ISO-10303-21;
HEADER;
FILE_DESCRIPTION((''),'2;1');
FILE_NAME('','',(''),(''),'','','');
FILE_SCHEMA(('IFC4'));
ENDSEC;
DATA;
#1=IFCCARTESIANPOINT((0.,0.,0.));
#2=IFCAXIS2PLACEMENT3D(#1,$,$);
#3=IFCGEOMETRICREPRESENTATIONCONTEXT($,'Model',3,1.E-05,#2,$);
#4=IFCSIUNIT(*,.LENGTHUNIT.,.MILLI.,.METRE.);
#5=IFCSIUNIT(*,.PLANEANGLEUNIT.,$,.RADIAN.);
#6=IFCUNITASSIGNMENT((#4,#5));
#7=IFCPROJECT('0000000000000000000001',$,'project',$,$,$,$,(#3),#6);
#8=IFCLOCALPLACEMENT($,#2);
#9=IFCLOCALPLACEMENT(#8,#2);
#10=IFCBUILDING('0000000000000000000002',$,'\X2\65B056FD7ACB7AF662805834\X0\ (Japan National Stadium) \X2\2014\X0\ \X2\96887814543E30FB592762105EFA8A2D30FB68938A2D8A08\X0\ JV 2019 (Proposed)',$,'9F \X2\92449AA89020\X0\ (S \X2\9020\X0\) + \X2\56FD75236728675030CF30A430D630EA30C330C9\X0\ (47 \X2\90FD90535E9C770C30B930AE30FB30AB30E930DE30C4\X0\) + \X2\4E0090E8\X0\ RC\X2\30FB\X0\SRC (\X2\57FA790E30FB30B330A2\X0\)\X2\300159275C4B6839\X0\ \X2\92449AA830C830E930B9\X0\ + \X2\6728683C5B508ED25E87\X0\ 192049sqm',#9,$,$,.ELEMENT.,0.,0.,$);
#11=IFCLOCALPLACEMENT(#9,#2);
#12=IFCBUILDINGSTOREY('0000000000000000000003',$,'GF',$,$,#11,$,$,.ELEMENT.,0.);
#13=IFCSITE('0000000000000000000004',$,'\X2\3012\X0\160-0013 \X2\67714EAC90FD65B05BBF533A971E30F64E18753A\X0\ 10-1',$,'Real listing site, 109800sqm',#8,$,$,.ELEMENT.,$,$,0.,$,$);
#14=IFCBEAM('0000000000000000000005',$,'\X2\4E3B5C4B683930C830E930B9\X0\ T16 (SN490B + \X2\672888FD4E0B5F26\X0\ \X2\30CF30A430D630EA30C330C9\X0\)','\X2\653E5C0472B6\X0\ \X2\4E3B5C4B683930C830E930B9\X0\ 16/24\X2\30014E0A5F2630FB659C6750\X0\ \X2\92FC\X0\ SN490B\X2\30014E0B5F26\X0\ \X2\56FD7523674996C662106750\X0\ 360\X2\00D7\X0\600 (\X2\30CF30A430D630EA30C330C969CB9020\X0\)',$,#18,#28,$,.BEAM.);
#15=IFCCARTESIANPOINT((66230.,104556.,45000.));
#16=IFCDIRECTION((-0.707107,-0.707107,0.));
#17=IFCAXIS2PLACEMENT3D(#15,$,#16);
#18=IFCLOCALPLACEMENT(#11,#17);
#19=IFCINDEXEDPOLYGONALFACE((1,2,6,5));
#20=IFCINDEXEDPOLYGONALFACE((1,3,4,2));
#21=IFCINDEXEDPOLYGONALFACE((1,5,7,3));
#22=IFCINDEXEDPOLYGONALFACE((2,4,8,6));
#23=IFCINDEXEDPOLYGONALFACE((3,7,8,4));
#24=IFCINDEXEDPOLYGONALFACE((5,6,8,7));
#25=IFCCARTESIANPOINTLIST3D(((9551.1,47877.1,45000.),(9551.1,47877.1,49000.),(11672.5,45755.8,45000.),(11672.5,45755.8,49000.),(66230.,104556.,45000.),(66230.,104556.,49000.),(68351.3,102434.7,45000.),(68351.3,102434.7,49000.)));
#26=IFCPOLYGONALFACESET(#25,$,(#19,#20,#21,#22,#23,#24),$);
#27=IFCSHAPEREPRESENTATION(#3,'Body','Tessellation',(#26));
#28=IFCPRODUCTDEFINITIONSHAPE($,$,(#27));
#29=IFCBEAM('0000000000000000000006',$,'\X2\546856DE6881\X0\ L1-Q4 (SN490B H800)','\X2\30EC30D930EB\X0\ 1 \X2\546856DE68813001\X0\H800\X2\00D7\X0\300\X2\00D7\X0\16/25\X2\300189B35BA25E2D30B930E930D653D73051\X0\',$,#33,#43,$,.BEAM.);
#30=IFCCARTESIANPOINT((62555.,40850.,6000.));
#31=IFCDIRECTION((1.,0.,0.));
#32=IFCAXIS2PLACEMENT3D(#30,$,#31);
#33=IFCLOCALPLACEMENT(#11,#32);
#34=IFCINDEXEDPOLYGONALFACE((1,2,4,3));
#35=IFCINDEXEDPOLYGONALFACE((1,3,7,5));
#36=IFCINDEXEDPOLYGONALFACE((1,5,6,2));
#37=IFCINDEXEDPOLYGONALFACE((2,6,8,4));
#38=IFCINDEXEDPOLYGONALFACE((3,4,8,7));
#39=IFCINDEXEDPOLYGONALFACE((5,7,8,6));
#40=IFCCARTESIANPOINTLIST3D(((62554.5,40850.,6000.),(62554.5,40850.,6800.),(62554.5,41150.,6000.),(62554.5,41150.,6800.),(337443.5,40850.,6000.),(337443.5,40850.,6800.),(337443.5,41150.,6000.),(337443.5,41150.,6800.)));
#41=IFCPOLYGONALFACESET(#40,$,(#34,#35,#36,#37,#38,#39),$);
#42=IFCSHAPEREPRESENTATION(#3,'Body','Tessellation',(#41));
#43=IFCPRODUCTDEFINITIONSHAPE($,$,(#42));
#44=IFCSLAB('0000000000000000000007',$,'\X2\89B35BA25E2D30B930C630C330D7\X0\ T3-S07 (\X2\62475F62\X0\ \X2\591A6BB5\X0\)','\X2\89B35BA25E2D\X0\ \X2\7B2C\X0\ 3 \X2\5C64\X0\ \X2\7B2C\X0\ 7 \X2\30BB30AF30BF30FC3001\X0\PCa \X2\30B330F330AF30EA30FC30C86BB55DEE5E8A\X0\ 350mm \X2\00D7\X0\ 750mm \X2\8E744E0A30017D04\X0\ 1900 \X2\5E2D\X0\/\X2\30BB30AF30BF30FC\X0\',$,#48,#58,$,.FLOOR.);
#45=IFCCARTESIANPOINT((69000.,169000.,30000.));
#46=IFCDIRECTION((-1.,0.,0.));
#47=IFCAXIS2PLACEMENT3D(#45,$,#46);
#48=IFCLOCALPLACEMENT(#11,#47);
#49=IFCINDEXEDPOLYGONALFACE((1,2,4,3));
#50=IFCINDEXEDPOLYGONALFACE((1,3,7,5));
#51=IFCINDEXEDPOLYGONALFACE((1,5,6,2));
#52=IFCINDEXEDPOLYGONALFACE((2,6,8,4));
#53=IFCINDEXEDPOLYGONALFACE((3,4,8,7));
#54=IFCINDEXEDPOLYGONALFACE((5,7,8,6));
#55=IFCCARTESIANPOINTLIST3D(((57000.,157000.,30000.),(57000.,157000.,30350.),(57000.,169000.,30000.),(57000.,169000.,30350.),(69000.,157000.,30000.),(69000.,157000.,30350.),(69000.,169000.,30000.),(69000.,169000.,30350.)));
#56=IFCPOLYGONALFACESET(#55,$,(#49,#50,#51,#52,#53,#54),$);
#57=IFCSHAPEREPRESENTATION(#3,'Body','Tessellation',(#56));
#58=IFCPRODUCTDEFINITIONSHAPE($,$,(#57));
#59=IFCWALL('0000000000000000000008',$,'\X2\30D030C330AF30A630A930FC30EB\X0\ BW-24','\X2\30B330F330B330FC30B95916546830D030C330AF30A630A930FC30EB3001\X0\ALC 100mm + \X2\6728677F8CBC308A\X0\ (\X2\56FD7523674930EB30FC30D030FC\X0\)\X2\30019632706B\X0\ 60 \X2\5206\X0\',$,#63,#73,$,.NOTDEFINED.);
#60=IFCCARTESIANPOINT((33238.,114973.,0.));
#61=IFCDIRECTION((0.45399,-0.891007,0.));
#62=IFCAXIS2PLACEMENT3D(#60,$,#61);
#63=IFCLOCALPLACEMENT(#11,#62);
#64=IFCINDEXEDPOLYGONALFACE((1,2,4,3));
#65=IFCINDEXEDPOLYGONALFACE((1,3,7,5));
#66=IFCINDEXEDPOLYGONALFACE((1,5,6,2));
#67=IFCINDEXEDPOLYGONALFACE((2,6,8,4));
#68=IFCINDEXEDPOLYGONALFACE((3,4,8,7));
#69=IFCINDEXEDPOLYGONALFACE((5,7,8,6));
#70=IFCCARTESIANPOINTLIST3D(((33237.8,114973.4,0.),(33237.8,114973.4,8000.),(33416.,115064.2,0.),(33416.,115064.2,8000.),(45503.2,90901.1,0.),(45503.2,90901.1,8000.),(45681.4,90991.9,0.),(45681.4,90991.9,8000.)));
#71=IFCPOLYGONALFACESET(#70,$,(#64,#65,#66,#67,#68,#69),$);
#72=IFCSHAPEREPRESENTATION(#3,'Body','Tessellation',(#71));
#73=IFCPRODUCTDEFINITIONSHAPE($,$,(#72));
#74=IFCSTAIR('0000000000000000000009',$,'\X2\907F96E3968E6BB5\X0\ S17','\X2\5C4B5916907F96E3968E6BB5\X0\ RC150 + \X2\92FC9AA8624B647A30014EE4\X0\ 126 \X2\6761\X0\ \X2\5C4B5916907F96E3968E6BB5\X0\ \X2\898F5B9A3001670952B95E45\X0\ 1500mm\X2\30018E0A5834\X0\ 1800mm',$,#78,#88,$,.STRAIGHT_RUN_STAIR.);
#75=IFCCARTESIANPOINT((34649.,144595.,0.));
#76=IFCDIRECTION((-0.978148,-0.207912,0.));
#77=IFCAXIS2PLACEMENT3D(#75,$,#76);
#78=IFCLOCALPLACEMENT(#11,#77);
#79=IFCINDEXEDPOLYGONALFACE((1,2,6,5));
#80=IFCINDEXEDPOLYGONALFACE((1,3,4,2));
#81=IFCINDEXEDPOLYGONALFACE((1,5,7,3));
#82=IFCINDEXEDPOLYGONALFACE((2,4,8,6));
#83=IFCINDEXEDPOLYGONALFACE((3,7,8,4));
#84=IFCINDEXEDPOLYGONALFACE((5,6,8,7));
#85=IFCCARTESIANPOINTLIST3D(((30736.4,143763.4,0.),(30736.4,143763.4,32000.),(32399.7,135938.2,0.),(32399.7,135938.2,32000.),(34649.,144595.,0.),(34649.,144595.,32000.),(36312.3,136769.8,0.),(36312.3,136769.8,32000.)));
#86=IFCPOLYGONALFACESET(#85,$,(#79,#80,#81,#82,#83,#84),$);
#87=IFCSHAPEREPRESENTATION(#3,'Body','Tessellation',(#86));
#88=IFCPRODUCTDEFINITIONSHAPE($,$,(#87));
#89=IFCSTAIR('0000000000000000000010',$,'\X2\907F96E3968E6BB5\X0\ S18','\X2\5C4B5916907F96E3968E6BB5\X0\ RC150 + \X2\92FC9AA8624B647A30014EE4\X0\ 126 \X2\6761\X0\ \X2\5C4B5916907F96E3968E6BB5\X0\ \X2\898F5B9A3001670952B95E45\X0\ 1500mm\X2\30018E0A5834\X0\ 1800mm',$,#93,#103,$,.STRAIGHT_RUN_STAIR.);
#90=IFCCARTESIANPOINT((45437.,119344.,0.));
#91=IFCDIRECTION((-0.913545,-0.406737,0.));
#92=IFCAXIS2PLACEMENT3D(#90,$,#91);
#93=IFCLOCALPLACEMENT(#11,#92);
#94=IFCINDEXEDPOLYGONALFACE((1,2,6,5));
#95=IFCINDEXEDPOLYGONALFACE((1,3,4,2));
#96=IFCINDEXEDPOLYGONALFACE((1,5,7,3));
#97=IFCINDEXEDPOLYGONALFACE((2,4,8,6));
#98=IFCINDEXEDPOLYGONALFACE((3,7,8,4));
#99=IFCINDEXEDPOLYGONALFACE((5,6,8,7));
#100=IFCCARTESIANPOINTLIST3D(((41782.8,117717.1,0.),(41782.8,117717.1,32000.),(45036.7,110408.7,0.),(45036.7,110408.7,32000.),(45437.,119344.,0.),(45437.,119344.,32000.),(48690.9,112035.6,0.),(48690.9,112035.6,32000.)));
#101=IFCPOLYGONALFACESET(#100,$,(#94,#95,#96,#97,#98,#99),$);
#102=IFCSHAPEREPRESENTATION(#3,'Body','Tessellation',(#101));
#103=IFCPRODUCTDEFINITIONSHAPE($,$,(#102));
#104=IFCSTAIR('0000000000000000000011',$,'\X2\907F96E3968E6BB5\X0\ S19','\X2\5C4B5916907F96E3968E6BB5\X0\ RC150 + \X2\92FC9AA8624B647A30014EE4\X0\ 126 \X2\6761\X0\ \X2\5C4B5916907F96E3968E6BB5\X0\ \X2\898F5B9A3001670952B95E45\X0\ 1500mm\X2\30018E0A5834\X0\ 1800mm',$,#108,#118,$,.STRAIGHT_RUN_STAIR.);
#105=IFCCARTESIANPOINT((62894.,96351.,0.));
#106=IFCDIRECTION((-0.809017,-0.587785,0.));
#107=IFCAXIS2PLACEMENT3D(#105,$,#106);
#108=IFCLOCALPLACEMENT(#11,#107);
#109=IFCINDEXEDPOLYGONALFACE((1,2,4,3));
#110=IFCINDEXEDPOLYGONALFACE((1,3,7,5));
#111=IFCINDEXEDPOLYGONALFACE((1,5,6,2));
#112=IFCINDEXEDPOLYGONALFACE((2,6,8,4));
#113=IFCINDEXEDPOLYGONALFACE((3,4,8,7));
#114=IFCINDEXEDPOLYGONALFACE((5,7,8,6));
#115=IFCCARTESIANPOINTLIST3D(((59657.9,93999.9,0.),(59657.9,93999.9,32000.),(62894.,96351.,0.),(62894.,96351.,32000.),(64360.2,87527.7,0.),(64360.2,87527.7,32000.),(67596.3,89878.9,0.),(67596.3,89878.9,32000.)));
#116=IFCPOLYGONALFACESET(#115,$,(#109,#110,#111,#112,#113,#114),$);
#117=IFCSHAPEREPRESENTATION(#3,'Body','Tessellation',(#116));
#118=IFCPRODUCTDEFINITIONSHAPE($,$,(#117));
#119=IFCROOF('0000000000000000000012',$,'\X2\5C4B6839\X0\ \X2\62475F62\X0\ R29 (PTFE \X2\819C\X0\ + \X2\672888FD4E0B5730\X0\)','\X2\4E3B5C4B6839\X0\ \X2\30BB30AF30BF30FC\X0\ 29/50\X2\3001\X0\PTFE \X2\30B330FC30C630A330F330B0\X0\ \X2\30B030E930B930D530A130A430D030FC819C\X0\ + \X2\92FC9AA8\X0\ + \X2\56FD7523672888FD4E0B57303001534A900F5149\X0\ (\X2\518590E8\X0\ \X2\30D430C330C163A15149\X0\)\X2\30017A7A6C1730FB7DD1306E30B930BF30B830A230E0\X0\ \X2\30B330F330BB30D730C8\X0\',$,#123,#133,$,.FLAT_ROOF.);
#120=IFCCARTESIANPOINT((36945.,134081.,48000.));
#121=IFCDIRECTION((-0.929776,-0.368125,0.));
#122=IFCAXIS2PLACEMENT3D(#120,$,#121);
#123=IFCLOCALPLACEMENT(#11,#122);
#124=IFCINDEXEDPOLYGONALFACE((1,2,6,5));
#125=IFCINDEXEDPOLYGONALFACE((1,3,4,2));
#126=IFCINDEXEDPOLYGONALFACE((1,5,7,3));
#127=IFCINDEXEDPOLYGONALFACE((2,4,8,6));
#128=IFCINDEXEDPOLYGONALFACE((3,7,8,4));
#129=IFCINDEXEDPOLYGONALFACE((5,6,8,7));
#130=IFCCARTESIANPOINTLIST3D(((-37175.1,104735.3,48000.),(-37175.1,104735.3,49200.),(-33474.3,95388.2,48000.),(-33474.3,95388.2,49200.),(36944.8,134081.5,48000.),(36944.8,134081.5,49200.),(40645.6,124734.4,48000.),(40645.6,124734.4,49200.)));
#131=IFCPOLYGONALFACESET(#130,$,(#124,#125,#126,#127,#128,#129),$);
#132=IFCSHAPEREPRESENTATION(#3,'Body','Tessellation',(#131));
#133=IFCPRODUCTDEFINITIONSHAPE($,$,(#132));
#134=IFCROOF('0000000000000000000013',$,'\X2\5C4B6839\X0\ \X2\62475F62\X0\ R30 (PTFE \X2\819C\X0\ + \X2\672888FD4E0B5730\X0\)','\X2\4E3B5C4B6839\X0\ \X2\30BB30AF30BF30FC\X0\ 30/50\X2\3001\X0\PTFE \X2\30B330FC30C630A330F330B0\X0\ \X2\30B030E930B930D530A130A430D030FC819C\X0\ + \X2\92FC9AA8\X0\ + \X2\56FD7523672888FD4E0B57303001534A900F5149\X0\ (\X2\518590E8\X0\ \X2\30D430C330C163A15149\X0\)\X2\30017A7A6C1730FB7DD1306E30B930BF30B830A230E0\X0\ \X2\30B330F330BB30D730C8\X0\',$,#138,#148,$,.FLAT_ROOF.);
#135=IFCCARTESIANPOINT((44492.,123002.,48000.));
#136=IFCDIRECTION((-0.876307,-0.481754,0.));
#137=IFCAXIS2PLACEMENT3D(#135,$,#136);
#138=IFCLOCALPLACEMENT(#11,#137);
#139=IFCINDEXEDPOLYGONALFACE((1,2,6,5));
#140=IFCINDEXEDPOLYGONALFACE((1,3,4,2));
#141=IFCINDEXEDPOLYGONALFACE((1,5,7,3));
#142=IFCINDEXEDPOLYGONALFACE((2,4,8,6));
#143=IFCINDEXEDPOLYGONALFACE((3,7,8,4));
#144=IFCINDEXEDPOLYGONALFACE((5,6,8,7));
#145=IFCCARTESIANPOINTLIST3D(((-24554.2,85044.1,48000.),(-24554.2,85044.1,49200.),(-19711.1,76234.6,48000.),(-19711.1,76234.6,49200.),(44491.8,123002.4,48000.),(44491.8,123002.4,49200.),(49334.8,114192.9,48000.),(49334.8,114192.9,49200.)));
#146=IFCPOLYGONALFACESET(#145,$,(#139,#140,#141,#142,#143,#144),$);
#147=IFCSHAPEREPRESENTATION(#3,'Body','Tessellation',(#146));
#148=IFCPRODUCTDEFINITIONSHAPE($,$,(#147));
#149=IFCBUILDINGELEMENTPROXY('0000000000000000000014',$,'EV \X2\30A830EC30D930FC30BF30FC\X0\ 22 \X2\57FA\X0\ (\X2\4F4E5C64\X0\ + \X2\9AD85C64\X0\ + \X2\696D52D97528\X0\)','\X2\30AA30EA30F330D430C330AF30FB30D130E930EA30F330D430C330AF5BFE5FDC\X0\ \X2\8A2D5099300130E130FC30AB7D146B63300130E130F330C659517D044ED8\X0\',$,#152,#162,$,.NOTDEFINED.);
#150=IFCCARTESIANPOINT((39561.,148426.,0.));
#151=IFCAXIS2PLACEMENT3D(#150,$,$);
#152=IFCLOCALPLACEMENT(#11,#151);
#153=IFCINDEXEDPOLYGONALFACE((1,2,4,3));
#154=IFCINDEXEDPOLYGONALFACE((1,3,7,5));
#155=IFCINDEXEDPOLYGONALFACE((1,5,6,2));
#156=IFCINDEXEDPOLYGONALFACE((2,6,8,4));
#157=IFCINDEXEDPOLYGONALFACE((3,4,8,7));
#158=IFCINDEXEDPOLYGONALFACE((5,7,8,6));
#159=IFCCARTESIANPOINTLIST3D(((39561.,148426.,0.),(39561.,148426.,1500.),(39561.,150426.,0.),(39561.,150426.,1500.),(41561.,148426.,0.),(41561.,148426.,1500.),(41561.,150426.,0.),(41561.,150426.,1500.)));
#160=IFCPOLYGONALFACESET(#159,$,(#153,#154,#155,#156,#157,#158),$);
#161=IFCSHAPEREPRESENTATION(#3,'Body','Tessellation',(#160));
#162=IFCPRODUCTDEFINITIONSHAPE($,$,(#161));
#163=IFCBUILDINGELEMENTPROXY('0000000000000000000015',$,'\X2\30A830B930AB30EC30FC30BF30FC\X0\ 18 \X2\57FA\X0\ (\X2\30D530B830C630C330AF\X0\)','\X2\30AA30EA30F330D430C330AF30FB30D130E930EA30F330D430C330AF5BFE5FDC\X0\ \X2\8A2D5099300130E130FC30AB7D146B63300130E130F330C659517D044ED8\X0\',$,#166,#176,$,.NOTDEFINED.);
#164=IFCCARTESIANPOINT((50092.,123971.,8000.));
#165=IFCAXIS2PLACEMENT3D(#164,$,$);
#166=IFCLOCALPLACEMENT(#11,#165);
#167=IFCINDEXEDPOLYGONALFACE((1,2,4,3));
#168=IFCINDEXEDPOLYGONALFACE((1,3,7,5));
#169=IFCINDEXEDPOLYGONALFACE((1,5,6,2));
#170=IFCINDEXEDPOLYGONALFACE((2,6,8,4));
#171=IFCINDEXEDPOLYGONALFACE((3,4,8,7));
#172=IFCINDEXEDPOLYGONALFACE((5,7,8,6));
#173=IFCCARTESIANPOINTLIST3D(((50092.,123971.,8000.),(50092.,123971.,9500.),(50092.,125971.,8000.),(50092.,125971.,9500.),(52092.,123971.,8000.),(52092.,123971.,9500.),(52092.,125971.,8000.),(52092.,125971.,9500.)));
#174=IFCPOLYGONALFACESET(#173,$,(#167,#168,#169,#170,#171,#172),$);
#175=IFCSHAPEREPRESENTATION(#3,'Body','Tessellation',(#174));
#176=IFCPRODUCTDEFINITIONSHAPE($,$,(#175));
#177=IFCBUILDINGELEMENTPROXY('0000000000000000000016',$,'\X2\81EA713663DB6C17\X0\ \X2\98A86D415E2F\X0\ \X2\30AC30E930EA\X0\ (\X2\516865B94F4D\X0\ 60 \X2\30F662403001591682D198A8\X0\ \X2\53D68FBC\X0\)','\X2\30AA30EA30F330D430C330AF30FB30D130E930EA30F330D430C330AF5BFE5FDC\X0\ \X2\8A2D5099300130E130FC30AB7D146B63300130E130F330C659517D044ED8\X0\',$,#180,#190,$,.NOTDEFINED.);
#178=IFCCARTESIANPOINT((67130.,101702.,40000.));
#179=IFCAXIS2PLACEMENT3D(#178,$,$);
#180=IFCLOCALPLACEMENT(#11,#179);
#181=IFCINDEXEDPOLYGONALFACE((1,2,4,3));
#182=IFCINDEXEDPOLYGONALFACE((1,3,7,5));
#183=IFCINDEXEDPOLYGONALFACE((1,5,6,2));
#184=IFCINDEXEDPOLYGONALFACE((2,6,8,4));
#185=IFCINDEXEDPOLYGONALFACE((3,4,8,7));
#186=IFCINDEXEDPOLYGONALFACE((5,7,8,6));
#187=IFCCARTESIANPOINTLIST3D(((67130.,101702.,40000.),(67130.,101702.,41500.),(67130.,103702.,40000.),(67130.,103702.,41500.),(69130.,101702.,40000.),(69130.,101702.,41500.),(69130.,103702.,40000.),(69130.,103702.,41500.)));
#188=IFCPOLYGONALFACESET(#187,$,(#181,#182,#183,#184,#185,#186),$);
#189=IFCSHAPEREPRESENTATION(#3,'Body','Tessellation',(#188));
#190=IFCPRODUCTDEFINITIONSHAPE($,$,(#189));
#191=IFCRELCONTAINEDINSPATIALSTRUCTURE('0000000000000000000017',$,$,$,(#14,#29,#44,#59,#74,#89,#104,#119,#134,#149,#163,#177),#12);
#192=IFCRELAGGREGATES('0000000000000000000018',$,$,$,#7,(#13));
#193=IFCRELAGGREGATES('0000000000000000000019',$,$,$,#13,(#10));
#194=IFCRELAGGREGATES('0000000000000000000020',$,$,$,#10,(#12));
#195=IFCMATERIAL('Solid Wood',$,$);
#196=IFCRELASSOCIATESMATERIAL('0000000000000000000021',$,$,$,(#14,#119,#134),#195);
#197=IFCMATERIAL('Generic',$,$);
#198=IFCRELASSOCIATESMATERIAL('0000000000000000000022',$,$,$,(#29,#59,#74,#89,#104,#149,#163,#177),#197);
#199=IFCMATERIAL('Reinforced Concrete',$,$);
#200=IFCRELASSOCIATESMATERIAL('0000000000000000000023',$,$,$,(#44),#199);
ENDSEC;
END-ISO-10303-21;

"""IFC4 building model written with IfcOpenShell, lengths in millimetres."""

from ifc_helpers import new_model, si_unit, frame, frame_2d, origin, place, context, project, spatial, rectangle, extrude, material, element, save


model = new_model("IFC4")

# Units and contexts
model_context = context("Model", 3, precision=1e-05, world=origin())
ifc_project = project(units=[si_unit("LENGTHUNIT", "METRE", prefix="MILLI"), si_unit("PLANEANGLEUNIT", "RADIAN")], contexts=[model_context])

# Site, building, storey
site_placement = place(None, origin())
site = spatial("IfcSite", under=ifc_project, at=site_placement, Name="〒160-0013 東京都新宿区霞ヶ丘町 10-1", ObjectType="Real listing site, 109800sqm", CompositionType="ELEMENT", RefElevation=0.0)
building_placement = place(site_placement, origin())
building = spatial("IfcBuilding", under=site, at=building_placement, Name="新国立競技場 (Japan National Stadium) — 隈研吾・大成建設・梓設計 JV 2019 (Proposed)", ObjectType="9F 鉄骨造 (S 造) + 国産木材ハイブリッド (47 都道府県スギ・カラマツ) + 一部 RC・SRC (基礎・コア)、大屋根 鉄骨トラス + 木格子軒庇 192049sqm", CompositionType="ELEMENT", ElevationOfRefHeight=0.0, ElevationOfTerrain=0.0)
storey_placement = place(building_placement, origin())
storey = spatial("IfcBuildingStorey", under=building, at=storey_placement, Name="GF", CompositionType="ELEMENT", Elevation=0.0)

# Shared definitions
ifc_material_1 = material(Name="Reinforced Concrete")

# Shared definitions
ifc_material_2 = material(Name="Generic")

# Beams
ifc_material_3 = material(Name="Solid Wood")
beam_1_placement = place(storey_placement, frame((66230.0, 104556.0, 45000.0), x_axis=(-0.707107, -0.707107, 0.0)))
element("IfcBeam", 1, at=beam_1_placement, inside=storey, material=ifc_material_3, Name="主屋根トラス T16 (SN490B + 木製下弦 ハイブリッド)", Description="放射状 主屋根トラス 16/24、上弦・斜材 鋼 SN490B、下弦 国産杉集成材 360×600 (ハイブリッド構造)", PredefinedType="BEAM", context=model_context, shape_type="SweptSolid", body=[
    extrude(rectangle(XDim=80156.0, YDim=3000.0, at=frame_2d((40078.0, 1500.0))), frame((66230.0, 104556.0, 45000.0), x_axis=(-0.707107, -0.707107, 0.0)), (0.0, 0.0, 1.0), 4000.0),
])
beam_2_placement = place(storey_placement, frame((62555.0, 40850.0, 6000.0), x_axis=(1.0, 0.0, 0.0)))
element("IfcBeam", 2, at=beam_2_placement, inside=storey, material=ifc_material_2, Name="周回梁 L1-Q4 (SN490B H800)", Description="レベル 1 周回梁、H800×300×16/25、観客席スラブ受け", PredefinedType="BEAM", context=model_context, shape_type="SweptSolid", body=[
    extrude(rectangle(XDim=274889.0, YDim=300.0, at=frame_2d((137444.0, 150.0))), frame((62555.0, 40850.0, 6000.0), x_axis=(1.0, 0.0, 0.0)), (0.0, 0.0, 1.0), 800.0),
])

# Slab
slab_placement = place(storey_placement, frame((69000.0, 169000.0, 30000.0), x_axis=(-1.0, 0.0, 0.0)))
element("IfcSlab", 3, at=slab_placement, inside=storey, material=ifc_material_1, Name="観客席ステップ T3-S07 (扇形 多段)", Description="観客席 第 3 層 第 7 セクター、PCa コンクリート段差床 350mm × 750mm 蹴上、約 1900 席/セクター", PredefinedType="FLOOR", context=model_context, shape_type="SweptSolid", body=[
    extrude(rectangle(XDim=12000.0, YDim=12000.0, at=frame_2d((6000.0, 6000.0))), frame((69000.0, 169000.0, 30000.0), x_axis=(-1.0, 0.0, 0.0)), (0.0, 0.0, 1.0), 350.0),
])

# Wall
wall_1_placement = place(storey_placement, frame((33238.0, 114973.0, 0.0), x_axis=(0.45399, -0.891007, 0.0)))
element("IfcWall", 4, at=wall_1_placement, inside=storey, material=ifc_material_2, Name="バックウォール BW-24", Description="コンコース外周バックウォール、ALC 100mm + 木板貼り (国産杉ルーバー)、防火 60 分", PredefinedType="NOTDEFINED", context=model_context, shape_type="SweptSolid", body=[
    extrude(rectangle(XDim=27017.0, YDim=200.0, at=frame_2d((13508.0, 100.0))), frame((33238.0, 114973.0, 0.0), x_axis=(0.45399, -0.891007, 0.0)), (0.0, 0.0, 1.0), 8000.0),
])

# Stairs
stair_1_placement = place(storey_placement, frame((34649.0, 144595.0, 0.0), x_axis=(-0.978148, -0.207912, 0.0)))
element("IfcStair", 5, at=stair_1_placement, inside=storey, material=ifc_material_2, Name="避難階段 S17", Description="屋外避難階段 RC150 + 鋼骨手摺、令 126 条 屋外避難階段 規定、有効幅 1500mm、踊場 1800mm", PredefinedType="STRAIGHT_RUN_STAIR", context=model_context, shape_type="SweptSolid", body=[
    extrude(rectangle(XDim=4000.0, YDim=8000.0, at=frame_2d((2000.0, 4000.0))), frame((34649.0, 144595.0, 0.0), x_axis=(-0.978148, -0.207912, 0.0)), (0.0, 0.0, 1.0), 32000.0),
])
stair_2_placement = place(storey_placement, frame((45437.0, 119344.0, 0.0), x_axis=(-0.913545, -0.406737, 0.0)))
element("IfcStair", 6, at=stair_2_placement, inside=storey, material=ifc_material_2, Name="避難階段 S18", Description="屋外避難階段 RC150 + 鋼骨手摺、令 126 条 屋外避難階段 規定、有効幅 1500mm、踊場 1800mm", PredefinedType="STRAIGHT_RUN_STAIR", context=model_context, shape_type="SweptSolid", body=[
    extrude(rectangle(XDim=4000.0, YDim=8000.0, at=frame_2d((2000.0, 4000.0))), frame((45437.0, 119344.0, 0.0), x_axis=(-0.913545, -0.406737, 0.0)), (0.0, 0.0, 1.0), 32000.0),
])
stair_3_placement = place(storey_placement, frame((62894.0, 96351.0, 0.0), x_axis=(-0.809017, -0.587785, 0.0)))
element("IfcStair", 7, at=stair_3_placement, inside=storey, material=ifc_material_2, Name="避難階段 S19", Description="屋外避難階段 RC150 + 鋼骨手摺、令 126 条 屋外避難階段 規定、有効幅 1500mm、踊場 1800mm", PredefinedType="STRAIGHT_RUN_STAIR", context=model_context, shape_type="SweptSolid", body=[
    extrude(rectangle(XDim=4000.0, YDim=8000.0, at=frame_2d((2000.0, 4000.0))), frame((62894.0, 96351.0, 0.0), x_axis=(-0.809017, -0.587785, 0.0)), (0.0, 0.0, 1.0), 32000.0),
])

# Roofs
roof_1_placement = place(storey_placement, frame((36945.0, 134081.0, 48000.0), x_axis=(-0.929776, -0.368125, 0.0)))
element("IfcRoof", 8, at=roof_1_placement, inside=storey, material=ifc_material_3, Name="屋根 扇形 R29 (PTFE 膜 + 木製下地)", Description="主屋根 セクター 29/50、PTFE コーティング グラスファイバー膜 + 鋼骨 + 国産木製下地、半透光 (内部 ピッチ採光)、空気・緑のスタジアム コンセプト", PredefinedType="FLAT_ROOF", context=model_context, shape_type="SweptSolid", body=[
    extrude(rectangle(XDim=79718.0, YDim=10053.0, at=frame_2d((39859.0, 5026.0))), frame((36945.0, 134081.0, 48000.0), x_axis=(-0.929776, -0.368125, 0.0)), (0.0, 0.0, 1.0), 1200.0),
])
roof_2_placement = place(storey_placement, frame((44492.0, 123002.0, 48000.0), x_axis=(-0.876307, -0.481754, 0.0)))
element("IfcRoof", 9, at=roof_2_placement, inside=storey, material=ifc_material_3, Name="屋根 扇形 R30 (PTFE 膜 + 木製下地)", Description="主屋根 セクター 30/50、PTFE コーティング グラスファイバー膜 + 鋼骨 + 国産木製下地、半透光 (内部 ピッチ採光)、空気・緑のスタジアム コンセプト", PredefinedType="FLAT_ROOF", context=model_context, shape_type="SweptSolid", body=[
    extrude(rectangle(XDim=78792.0, YDim=10053.0, at=frame_2d((39396.0, 5026.0))), frame((44492.0, 123002.0, 48000.0), x_axis=(-0.876307, -0.481754, 0.0)), (0.0, 0.0, 1.0), 1200.0),
])

# Building element proxies
proxy_1_placement = place(storey_placement, frame((39561.0, 148426.0, 0.0)))
element("IfcBuildingElementProxy", 10, at=proxy_1_placement, inside=storey, material=ifc_material_2, Name="EV エレベーター 22 基 (低層 + 高層 + 業務用)", Description="オリンピック・パラリンピック対応 設備、メーカ純正、メンテ契約付", PredefinedType="NOTDEFINED", context=model_context, shape_type="SweptSolid", body=[
    extrude(rectangle(XDim=2000.0, YDim=2000.0, at=frame_2d((1000.0, 1000.0))), frame((39561.0, 148426.0, 0.0)), (0.0, 0.0, 1.0), 1500.0),
])
proxy_2_placement = place(storey_placement, frame((50092.0, 123971.0, 8000.0)))
element("IfcBuildingElementProxy", 11, at=proxy_2_placement, inside=storey, material=ifc_material_2, Name="エスカレーター 18 基 (フジテック)", Description="オリンピック・パラリンピック対応 設備、メーカ純正、メンテ契約付", PredefinedType="NOTDEFINED", context=model_context, shape_type="SweptSolid", body=[
    extrude(rectangle(XDim=2000.0, YDim=2000.0, at=frame_2d((1000.0, 1000.0))), frame((50092.0, 123971.0, 8000.0)), (0.0, 0.0, 1.0), 1500.0),
])
proxy_3_placement = place(storey_placement, frame((67130.0, 101702.0, 40000.0)))
element("IfcBuildingElementProxy", 12, at=proxy_3_placement, inside=storey, material=ifc_material_2, Name="自然換気 風流帯 ガラリ (全方位 60 ヶ所、外苑風 取込)", Description="オリンピック・パラリンピック対応 設備、メーカ純正、メンテ契約付", PredefinedType="NOTDEFINED", context=model_context, shape_type="SweptSolid", body=[
    extrude(rectangle(XDim=2000.0, YDim=2000.0, at=frame_2d((1000.0, 1000.0))), frame((67130.0, 101702.0, 40000.0)), (0.0, 0.0, 1.0), 1500.0),
])

save(model, "model.ifc")
